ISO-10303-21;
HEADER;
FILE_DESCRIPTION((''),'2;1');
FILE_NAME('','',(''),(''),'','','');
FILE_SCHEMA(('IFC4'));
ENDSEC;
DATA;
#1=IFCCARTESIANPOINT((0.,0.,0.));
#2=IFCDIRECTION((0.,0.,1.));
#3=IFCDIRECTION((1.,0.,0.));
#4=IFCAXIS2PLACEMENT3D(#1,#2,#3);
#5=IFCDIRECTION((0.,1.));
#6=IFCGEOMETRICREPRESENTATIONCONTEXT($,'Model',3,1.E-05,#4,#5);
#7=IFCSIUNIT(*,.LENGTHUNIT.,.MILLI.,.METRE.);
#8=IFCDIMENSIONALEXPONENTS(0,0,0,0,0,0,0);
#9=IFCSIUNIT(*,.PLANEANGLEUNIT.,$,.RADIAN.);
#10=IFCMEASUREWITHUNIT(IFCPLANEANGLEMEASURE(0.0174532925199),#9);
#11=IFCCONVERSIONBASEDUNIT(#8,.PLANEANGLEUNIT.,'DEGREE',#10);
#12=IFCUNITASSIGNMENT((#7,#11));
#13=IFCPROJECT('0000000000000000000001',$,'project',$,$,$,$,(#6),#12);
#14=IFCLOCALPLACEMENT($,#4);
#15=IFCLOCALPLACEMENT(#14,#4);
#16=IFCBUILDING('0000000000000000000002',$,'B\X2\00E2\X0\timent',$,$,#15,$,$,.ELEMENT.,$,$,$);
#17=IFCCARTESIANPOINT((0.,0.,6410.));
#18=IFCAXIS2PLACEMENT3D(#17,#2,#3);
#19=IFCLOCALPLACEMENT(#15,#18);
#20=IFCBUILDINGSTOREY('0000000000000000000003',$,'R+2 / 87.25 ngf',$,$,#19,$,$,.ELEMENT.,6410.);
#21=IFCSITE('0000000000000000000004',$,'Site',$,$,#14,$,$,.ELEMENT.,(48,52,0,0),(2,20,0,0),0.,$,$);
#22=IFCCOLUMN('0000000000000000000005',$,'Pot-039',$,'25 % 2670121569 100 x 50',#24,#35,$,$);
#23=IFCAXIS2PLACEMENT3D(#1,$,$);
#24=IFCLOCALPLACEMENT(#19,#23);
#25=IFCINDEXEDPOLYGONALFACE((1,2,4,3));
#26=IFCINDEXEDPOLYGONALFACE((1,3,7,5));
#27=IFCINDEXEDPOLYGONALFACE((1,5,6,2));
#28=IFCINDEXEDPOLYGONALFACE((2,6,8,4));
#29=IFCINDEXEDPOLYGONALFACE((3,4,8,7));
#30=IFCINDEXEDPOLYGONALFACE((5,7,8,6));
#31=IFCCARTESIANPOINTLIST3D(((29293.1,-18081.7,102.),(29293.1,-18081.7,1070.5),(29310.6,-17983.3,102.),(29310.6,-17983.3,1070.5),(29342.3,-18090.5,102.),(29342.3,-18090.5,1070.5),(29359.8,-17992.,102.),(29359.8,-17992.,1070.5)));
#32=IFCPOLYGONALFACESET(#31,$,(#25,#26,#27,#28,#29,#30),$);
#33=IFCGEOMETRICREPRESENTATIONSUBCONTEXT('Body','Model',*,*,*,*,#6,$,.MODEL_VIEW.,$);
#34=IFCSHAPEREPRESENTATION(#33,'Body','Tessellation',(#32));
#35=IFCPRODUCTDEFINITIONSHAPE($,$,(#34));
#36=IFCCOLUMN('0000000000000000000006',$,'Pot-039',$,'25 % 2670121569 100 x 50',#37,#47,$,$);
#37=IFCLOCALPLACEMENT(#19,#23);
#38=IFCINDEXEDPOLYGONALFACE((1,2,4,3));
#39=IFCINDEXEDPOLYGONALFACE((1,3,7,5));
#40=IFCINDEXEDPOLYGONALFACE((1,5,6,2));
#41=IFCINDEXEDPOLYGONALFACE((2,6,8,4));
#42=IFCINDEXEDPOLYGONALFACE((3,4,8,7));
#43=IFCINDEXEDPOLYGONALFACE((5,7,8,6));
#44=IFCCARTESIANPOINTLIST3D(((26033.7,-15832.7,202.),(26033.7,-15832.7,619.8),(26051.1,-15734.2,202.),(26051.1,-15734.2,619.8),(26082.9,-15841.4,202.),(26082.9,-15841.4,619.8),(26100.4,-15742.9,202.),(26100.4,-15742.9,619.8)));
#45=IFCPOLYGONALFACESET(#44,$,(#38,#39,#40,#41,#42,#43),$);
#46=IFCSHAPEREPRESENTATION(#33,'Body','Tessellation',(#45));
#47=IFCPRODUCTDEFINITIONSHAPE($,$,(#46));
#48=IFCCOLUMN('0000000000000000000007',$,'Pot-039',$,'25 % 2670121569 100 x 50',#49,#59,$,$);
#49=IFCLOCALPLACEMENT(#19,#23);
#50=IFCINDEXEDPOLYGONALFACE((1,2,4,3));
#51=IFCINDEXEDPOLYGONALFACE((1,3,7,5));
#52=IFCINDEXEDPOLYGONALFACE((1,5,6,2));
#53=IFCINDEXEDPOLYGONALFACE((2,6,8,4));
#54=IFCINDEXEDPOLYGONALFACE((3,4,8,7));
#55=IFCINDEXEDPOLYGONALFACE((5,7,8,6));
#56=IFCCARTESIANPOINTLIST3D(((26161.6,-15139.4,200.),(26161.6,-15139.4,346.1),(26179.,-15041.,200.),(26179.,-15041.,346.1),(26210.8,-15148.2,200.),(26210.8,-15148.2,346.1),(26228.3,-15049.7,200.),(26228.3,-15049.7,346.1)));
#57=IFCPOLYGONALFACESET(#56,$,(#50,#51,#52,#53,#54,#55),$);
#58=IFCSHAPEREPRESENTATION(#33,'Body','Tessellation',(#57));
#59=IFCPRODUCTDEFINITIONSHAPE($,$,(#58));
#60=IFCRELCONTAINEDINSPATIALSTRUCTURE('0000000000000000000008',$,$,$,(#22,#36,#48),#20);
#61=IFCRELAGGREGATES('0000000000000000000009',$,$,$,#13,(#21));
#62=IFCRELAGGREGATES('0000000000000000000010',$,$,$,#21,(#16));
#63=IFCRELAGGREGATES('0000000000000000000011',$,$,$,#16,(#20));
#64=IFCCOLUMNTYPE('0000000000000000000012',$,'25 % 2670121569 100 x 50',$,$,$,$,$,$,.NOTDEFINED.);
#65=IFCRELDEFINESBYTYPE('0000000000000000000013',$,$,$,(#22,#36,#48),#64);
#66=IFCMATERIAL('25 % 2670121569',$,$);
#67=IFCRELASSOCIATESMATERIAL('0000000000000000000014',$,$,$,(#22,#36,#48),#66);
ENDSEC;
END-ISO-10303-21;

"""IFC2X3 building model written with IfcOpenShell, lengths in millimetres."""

from ifc_helpers import new_model, entity, si_unit, converted_unit, direction, frame, origin_with_axes, origin_2d_with_axis, place, context, subcontext, project, spatial, rectangle, extrude, material, type_object, element, save


model = new_model("IFC2X3")

# Units and contexts
model_context = context("Model", 3, precision=1e-05, world=origin_with_axes(), true_north=direction((0.0, 1.0)))
body_context = subcontext(model_context, "Body", "Model", "MODEL_VIEW")
ifc_project = project(units=[si_unit("LENGTHUNIT", "METRE", prefix="MILLI"), converted_unit("PLANEANGLEUNIT", "DEGREE", entity("IfcPlaneAngleMeasure", 0.0174532925199), si_unit("PLANEANGLEUNIT", "RADIAN"), dimensions=[0, 0, 0, 0, 0, 0, 0])], contexts=[model_context])

# Site, building, storey
site_placement = place(None, origin_with_axes())
site = spatial("IfcSite", under=ifc_project, at=site_placement, Name="Site", CompositionType="ELEMENT", RefLatitude=(48, 52, 0, 0), RefLongitude=(2, 20, 0, 0), RefElevation=0.0)
building_placement = place(site_placement, origin_with_axes())
building = spatial("IfcBuilding", under=site, at=building_placement, Name="Bâtiment", CompositionType="ELEMENT")
storey_placement = place(building_placement, frame((0.0, 0.0, 6410.0), z_axis=(0.0, 0.0, 1.0), x_axis=(1.0, 0.0, 0.0)))
storey = spatial("IfcBuildingStorey", under=building, at=storey_placement, Name="R+2 / 87.25 ngf", CompositionType="ELEMENT", Elevation=6410.0)

# Columns
ifc_material_1 = material(Name="25 % 2670121569")
column_type = type_object("IfcColumnType", Name="25 % 2670121569 100 x 50", PredefinedType="NOTDEFINED")
column_1_placement = place(storey_placement, frame((29326.5, -18036.9, 102.0), z_axis=(0.0, 0.0, 1.0), x_axis=(0.17478, 0.984607, 0.0)))
element("IfcColumn", 1, at=column_1_placement, inside=storey, type_object=column_type, material=ifc_material_1, Name="Pot-039", ObjectType="25 % 2670121569 100 x 50", context=body_context, shape_type="SweptSolid", body=[
    extrude(rectangle(XDim=100.0, YDim=50.0, at=origin_2d_with_axis()), origin_with_axes(), (0.0, 0.0, 1.0), 968.5),
])
column_2_placement = place(storey_placement, frame((26067.0, -15787.8, 202.0), z_axis=(0.0, 0.0, 1.0), x_axis=(0.17478, 0.984607, 0.0)))
element("IfcColumn", 2, at=column_2_placement, inside=storey, type_object=column_type, material=ifc_material_1, Name="Pot-039", ObjectType="25 % 2670121569 100 x 50", context=body_context, shape_type="SweptSolid", body=[
    extrude(rectangle(XDim=100.0, YDim=50.0, at=origin_2d_with_axis()), origin_with_axes(), (0.0, 0.0, 1.0), 417.8),
])
column_3_placement = place(storey_placement, frame((26194.9, -15094.6, 200.0), z_axis=(0.0, 0.0, 1.0), x_axis=(0.174407, 0.984674, 0.0)))
element("IfcColumn", 3, at=column_3_placement, inside=storey, type_object=column_type, material=ifc_material_1, Name="Pot-039", ObjectType="25 % 2670121569 100 x 50", context=body_context, shape_type="SweptSolid", body=[
    extrude(rectangle(XDim=100.0, YDim=50.0, at=origin_2d_with_axis()), origin_with_axes(), (0.0, 0.0, 1.0), 146.1),
])

save(model, "model.ifc")
